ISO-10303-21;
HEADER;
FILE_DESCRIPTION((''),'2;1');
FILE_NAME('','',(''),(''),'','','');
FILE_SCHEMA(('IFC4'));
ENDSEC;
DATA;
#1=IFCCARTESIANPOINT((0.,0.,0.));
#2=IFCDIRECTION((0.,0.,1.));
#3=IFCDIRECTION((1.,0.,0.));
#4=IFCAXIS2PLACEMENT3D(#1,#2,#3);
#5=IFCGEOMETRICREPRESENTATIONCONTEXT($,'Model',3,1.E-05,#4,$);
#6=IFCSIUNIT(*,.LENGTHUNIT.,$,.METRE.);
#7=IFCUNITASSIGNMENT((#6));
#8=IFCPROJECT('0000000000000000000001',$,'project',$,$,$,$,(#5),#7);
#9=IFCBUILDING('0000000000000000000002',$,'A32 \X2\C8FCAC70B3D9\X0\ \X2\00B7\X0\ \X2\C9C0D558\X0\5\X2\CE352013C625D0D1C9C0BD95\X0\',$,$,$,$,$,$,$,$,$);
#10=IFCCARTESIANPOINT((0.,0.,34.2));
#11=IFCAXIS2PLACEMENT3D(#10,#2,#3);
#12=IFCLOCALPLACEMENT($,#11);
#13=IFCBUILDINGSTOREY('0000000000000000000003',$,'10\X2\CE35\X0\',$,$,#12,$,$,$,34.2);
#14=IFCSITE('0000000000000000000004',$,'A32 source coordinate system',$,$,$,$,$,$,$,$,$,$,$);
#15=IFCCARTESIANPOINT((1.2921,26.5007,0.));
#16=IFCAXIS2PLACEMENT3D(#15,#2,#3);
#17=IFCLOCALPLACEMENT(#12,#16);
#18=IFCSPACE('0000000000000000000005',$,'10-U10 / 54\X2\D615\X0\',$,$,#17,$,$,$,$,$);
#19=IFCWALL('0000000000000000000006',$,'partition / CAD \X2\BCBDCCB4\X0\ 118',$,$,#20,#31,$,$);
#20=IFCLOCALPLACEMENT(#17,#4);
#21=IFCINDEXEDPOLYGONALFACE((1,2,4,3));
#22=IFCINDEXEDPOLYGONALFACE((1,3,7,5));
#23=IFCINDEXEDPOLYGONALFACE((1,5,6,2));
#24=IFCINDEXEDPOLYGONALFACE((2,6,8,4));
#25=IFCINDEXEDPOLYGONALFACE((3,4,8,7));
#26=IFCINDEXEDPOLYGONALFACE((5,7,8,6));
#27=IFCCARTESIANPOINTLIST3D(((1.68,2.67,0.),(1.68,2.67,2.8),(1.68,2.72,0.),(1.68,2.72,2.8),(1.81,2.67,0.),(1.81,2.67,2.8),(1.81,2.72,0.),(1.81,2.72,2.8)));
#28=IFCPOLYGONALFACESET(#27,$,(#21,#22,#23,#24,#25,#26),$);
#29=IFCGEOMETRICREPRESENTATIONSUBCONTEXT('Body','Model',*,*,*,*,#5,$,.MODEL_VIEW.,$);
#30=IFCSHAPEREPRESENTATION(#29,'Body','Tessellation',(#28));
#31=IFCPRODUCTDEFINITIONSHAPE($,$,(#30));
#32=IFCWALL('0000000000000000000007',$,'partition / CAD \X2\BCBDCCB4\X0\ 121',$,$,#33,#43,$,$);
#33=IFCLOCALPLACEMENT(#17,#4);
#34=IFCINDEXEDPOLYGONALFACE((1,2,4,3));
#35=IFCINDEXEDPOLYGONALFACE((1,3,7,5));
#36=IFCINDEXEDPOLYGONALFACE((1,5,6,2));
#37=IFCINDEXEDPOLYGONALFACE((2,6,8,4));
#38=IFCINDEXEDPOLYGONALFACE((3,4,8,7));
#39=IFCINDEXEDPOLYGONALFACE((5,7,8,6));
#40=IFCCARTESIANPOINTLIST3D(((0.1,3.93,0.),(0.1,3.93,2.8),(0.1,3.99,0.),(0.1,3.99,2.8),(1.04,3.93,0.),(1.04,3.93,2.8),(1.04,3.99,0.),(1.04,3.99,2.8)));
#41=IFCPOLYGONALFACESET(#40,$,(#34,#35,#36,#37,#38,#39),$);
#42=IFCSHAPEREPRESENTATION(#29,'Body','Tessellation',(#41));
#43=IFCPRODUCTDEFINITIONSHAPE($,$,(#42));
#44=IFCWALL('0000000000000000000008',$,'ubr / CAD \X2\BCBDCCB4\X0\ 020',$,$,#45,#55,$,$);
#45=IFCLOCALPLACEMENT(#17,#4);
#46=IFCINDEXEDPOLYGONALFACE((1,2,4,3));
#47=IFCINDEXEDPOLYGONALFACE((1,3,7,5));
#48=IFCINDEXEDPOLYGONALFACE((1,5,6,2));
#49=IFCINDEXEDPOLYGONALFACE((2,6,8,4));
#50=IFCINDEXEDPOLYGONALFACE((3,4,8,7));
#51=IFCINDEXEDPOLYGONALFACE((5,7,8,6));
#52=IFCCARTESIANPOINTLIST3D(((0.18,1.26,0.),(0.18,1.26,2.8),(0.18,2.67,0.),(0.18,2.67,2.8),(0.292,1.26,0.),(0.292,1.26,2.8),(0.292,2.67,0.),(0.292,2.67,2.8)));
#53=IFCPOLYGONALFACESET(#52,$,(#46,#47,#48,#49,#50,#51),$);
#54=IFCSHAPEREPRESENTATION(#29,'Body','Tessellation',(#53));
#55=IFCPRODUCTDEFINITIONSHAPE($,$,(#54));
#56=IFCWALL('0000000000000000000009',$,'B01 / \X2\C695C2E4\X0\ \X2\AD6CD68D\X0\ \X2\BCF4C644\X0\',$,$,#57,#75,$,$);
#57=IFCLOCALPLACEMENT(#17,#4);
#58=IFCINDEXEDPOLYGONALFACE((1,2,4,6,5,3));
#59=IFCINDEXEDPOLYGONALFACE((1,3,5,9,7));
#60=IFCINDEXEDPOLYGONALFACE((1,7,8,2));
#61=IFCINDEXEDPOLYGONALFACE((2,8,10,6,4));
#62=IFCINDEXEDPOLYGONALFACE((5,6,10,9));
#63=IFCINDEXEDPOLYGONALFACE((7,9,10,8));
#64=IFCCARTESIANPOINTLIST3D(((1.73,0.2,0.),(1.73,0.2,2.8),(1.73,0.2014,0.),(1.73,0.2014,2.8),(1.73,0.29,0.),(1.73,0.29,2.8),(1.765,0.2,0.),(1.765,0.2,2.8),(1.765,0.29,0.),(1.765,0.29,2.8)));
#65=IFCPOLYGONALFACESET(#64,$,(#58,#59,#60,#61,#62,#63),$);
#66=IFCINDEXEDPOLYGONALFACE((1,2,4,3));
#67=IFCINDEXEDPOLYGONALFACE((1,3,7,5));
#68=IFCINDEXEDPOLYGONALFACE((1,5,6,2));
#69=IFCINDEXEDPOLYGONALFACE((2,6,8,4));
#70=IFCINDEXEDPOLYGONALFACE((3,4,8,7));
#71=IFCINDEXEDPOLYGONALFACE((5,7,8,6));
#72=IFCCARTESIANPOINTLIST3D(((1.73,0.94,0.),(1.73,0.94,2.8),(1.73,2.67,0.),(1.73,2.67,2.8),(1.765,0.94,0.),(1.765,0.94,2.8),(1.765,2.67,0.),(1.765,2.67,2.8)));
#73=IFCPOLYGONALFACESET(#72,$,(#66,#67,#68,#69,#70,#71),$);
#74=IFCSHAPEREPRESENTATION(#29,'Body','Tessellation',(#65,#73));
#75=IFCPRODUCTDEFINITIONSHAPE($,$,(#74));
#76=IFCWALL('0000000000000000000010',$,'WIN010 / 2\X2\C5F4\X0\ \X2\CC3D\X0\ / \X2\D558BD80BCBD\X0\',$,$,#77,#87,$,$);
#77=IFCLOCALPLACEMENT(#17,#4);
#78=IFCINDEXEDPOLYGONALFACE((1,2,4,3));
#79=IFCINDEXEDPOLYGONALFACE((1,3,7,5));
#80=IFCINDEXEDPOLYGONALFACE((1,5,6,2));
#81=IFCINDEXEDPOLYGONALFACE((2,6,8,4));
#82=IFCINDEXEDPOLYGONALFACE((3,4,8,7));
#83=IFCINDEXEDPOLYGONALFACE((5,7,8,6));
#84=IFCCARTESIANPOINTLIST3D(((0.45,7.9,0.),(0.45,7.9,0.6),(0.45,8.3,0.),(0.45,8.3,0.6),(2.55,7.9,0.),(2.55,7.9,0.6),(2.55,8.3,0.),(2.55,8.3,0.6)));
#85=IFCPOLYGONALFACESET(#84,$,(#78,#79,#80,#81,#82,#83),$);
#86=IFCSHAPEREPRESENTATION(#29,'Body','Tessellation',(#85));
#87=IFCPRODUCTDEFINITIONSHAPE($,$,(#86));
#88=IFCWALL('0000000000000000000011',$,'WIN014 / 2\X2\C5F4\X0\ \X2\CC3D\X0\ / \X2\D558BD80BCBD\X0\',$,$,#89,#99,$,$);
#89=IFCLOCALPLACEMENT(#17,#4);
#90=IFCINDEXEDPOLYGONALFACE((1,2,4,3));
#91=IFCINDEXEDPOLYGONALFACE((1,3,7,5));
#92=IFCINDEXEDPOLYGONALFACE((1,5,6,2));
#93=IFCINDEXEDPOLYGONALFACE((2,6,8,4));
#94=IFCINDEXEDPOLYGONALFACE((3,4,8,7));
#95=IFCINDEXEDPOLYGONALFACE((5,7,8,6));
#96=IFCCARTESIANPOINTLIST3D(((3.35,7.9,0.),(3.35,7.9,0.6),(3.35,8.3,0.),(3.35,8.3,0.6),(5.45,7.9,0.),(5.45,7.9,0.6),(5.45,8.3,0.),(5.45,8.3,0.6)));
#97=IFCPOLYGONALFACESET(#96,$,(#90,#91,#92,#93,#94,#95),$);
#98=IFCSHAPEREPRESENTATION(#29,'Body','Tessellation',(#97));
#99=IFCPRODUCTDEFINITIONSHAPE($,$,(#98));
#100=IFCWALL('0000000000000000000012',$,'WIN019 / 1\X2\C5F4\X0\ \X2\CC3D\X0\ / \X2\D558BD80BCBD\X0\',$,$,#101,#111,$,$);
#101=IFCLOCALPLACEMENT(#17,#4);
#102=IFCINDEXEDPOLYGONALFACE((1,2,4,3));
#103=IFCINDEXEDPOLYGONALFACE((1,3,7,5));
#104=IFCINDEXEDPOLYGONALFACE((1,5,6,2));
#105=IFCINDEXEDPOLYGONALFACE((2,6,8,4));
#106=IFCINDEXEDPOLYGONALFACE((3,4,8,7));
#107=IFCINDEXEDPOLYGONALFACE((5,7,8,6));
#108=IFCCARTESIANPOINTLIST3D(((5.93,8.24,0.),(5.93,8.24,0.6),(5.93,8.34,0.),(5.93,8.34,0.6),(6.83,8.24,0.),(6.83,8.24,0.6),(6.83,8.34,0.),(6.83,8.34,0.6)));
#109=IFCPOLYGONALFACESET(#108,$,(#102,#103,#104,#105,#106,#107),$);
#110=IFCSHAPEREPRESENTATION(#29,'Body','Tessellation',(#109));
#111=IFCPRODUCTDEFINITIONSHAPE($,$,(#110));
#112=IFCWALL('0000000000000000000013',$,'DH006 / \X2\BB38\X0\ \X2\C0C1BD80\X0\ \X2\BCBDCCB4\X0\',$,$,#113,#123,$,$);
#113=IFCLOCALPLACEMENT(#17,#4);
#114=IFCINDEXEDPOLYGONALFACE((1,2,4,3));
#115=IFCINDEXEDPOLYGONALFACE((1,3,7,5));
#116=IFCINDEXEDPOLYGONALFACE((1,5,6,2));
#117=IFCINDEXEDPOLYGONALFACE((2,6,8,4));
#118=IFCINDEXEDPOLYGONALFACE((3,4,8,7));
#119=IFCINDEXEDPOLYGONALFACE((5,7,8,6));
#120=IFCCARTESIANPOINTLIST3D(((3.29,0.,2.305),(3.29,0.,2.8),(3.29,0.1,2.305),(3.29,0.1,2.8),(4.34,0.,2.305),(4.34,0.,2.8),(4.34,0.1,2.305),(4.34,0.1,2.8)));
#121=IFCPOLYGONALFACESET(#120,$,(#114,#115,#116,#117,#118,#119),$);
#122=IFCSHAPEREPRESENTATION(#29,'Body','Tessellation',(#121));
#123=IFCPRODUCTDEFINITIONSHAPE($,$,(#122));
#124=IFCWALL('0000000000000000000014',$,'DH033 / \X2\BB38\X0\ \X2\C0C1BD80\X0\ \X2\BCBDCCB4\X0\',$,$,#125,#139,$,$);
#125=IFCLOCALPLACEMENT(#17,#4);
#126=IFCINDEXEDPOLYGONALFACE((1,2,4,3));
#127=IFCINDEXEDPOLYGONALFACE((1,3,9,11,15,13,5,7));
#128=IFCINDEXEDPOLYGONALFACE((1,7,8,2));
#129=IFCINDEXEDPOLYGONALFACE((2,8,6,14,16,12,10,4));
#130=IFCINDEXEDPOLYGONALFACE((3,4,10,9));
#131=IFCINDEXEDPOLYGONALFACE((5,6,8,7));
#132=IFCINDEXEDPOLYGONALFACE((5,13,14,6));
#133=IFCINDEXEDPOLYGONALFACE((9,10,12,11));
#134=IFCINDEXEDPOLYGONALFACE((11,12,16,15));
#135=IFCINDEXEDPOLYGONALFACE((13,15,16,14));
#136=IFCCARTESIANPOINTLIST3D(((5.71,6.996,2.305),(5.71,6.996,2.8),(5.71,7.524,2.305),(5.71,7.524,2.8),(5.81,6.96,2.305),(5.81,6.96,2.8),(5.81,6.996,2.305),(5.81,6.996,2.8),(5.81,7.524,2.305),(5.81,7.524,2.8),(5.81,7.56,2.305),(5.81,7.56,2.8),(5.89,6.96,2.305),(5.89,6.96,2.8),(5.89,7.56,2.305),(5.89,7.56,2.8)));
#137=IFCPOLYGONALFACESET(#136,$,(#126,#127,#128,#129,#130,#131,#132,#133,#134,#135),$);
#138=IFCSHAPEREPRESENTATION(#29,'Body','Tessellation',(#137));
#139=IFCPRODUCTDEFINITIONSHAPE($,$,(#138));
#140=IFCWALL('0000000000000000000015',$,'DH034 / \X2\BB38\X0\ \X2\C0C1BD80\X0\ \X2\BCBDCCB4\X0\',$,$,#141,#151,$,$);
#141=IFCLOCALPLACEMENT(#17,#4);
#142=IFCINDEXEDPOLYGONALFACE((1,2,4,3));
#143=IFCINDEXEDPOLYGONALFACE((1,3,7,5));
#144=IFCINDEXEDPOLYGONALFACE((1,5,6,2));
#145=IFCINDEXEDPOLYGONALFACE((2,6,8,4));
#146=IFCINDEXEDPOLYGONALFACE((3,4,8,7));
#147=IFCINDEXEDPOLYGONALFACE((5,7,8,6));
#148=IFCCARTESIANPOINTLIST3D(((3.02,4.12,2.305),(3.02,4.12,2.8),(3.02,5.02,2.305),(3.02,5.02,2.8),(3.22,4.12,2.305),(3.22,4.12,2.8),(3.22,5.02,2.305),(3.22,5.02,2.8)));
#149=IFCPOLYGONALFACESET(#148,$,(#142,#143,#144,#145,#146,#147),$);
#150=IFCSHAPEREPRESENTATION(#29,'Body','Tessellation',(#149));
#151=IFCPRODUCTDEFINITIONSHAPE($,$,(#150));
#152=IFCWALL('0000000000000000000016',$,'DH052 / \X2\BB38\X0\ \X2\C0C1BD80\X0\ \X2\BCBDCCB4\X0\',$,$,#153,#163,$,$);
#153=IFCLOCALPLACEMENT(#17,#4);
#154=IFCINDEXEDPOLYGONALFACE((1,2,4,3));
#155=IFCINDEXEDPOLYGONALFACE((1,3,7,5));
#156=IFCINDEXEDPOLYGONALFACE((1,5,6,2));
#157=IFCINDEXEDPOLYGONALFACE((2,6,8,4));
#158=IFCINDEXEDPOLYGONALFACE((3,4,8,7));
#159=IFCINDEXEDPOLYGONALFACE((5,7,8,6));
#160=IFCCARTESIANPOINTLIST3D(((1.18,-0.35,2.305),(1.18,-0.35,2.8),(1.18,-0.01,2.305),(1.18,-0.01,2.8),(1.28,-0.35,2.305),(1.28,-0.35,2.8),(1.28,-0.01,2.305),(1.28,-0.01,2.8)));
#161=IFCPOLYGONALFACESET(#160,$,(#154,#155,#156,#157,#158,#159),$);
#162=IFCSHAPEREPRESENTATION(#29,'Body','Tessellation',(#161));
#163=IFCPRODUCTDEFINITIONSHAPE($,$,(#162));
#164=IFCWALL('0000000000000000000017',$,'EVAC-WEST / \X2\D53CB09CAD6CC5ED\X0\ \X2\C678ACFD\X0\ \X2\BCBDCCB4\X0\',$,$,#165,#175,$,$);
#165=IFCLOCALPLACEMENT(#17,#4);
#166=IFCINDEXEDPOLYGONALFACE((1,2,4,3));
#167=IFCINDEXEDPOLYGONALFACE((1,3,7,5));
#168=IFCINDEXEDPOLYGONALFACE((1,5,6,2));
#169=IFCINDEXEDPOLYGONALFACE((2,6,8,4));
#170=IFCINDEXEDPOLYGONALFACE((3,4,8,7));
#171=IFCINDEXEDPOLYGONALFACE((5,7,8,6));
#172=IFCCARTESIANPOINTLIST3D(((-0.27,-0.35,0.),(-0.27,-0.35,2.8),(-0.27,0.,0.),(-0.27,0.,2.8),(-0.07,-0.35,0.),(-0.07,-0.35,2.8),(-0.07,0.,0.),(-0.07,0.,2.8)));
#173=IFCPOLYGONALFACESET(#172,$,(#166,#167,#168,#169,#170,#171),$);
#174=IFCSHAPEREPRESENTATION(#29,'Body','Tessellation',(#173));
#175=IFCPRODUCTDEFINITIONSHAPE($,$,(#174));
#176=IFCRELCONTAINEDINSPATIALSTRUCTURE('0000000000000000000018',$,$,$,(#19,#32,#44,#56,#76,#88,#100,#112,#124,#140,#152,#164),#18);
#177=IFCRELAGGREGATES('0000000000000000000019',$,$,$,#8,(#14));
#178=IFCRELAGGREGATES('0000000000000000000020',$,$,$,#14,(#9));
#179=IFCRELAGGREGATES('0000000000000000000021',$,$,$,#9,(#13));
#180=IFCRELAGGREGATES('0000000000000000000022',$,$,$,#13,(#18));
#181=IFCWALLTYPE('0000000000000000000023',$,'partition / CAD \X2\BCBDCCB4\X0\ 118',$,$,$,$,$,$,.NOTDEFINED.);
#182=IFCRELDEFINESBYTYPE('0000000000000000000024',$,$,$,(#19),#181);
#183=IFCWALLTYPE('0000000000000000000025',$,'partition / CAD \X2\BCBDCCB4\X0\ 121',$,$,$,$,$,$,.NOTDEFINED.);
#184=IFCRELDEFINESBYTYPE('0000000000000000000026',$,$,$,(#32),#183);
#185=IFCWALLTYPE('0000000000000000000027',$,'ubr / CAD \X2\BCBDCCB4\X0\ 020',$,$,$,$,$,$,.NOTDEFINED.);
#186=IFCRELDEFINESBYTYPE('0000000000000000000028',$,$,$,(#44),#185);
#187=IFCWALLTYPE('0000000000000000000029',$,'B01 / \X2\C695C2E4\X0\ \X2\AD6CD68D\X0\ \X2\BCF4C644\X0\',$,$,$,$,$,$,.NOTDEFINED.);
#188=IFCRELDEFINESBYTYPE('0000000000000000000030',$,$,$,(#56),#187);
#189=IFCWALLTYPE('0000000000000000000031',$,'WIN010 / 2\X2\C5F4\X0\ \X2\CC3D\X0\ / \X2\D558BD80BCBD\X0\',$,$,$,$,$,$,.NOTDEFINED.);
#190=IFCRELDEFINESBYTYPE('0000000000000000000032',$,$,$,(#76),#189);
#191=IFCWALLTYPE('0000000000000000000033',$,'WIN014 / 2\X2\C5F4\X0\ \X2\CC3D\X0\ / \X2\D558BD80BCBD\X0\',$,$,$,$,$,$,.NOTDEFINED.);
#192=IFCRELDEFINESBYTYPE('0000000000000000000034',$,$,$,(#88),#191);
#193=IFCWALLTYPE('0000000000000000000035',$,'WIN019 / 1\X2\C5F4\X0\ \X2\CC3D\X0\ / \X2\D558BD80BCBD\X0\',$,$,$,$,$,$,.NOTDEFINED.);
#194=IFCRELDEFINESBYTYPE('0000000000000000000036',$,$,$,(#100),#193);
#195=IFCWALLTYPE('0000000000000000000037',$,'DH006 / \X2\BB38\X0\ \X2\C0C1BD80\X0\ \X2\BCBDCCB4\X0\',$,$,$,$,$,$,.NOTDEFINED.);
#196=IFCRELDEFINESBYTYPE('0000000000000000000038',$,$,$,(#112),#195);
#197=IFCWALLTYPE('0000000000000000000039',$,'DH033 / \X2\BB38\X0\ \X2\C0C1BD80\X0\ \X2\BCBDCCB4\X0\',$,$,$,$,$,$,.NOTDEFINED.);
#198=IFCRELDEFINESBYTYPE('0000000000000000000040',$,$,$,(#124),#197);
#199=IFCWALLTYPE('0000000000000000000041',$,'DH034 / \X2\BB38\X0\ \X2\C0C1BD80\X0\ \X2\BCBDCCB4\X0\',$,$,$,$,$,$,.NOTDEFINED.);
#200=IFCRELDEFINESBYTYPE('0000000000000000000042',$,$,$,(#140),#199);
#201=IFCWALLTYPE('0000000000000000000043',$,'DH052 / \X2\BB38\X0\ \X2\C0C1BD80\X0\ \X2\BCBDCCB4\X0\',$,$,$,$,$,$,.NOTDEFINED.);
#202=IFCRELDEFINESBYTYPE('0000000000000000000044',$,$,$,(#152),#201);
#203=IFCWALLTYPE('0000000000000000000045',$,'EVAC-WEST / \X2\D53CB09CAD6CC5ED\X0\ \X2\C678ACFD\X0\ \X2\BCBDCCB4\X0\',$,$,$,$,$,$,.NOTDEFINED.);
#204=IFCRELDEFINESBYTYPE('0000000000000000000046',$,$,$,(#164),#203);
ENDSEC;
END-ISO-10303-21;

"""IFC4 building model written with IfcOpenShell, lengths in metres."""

from ifc_helpers import new_model, si_unit, frame, origin, origin_with_axes, place, context, subcontext, project, spatial, polyline, outline, extrude, source, transform, mapped, type_object, type_shapes, element, save


model = new_model("IFC4")

# Units and contexts
model_context = context("Model", 3, precision=1e-05, world=origin_with_axes())
body_context = subcontext(model_context, "Body", "Model", "MODEL_VIEW")
ifc_project = project(units=[si_unit("LENGTHUNIT", "METRE")], contexts=[model_context])

# Site, building, storey, space
site = spatial("IfcSite", under=ifc_project, Name="A32 source coordinate system")
building = spatial("IfcBuilding", under=site, Name="A32 주거동 · 지하5층–옥탑지붕")
storey_placement = place(None, frame((0.0, 0.0, 34.2), z_axis=(0.0, 0.0, 1.0), x_axis=(1.0, 0.0, 0.0)))
storey = spatial("IfcBuildingStorey", under=building, at=storey_placement, Name="10층", Elevation=34.2)
space_placement = place(storey_placement, frame((1.2921, 26.5007, 0.0), z_axis=(0.0, 0.0, 1.0), x_axis=(1.0, 0.0, 0.0)))
space = spatial("IfcSpace", under=storey, at=space_placement, Name="10-U10 / 54형")

# Walls
wall_type_1 = type_object("IfcWallType", Name="partition / CAD 벽체 118", PredefinedType="NOTDEFINED")
shared_shape_1 = source(origin(), body_context, "Body", "SweptSolid", [
    extrude(outline(polyline([(1.81, 2.67), (1.68, 2.67), (1.68, 2.72), (1.81, 2.72), (1.81, 2.67)])), origin(), (0.0, 0.0, 1.0), 2.8),
])
type_shapes(wall_type_1, [shared_shape_1])
wall_1_placement = place(space_placement, origin_with_axes())
element("IfcWall", 1, at=wall_1_placement, inside=space, type_object=wall_type_1, Name="partition / CAD 벽체 118", context=body_context, shape_type="MappedRepresentation", body=[
    mapped(shared_shape_1, transform((0.0, 0.0, 0.0), scale=1.0)),
])
wall_type_2 = type_object("IfcWallType", Name="partition / CAD 벽체 121", PredefinedType="NOTDEFINED")
shared_shape_2 = source(origin(), body_context, "Body", "SweptSolid", [
    extrude(outline(polyline([(0.1, 3.99), (1.04, 3.99), (1.04, 3.93), (0.1, 3.93), (0.1, 3.99)])), origin(), (0.0, 0.0, 1.0), 2.8),
])
type_shapes(wall_type_2, [shared_shape_2])
wall_2_placement = place(space_placement, origin_with_axes())
element("IfcWall", 2, at=wall_2_placement, inside=space, type_object=wall_type_2, Name="partition / CAD 벽체 121", context=body_context, shape_type="MappedRepresentation", body=[
    mapped(shared_shape_2, transform((0.0, 0.0, 0.0), scale=1.0)),
])
wall_type_3 = type_object("IfcWallType", Name="ubr / CAD 벽체 020", PredefinedType="NOTDEFINED")
shared_shape_3 = source(origin(), body_context, "Body", "SweptSolid", [
    extrude(outline(polyline([(0.18, 1.26), (0.18, 2.67), (0.292, 2.67), (0.292, 1.26), (0.18, 1.26)])), origin(), (0.0, 0.0, 1.0), 2.8),
])
type_shapes(wall_type_3, [shared_shape_3])
wall_3_placement = place(space_placement, origin_with_axes())
element("IfcWall", 3, at=wall_3_placement, inside=space, type_object=wall_type_3, Name="ubr / CAD 벽체 020", context=body_context, shape_type="MappedRepresentation", body=[
    mapped(shared_shape_3, transform((0.0, 0.0, 0.0), scale=1.0)),
])
wall_type_4 = type_object("IfcWallType", Name="B01 / 욕실 구획 보완", PredefinedType="NOTDEFINED")
shared_shape_4 = source(origin(), body_context, "Body", "SweptSolid", [
    extrude(outline(polyline([(1.765, 0.2), (1.73, 0.2), (1.73, 0.2014), (1.73, 0.29), (1.765, 0.29), (1.765, 0.2)])), origin(), (0.0, 0.0, 1.0), 2.8),
    extrude(outline(polyline([(1.765, 2.67), (1.765, 0.94), (1.73, 0.94), (1.73, 2.67), (1.765, 2.67)])), origin(), (0.0, 0.0, 1.0), 2.8),
])
type_shapes(wall_type_4, [shared_shape_4])
wall_4_placement = place(space_placement, origin_with_axes())
element("IfcWall", 4, at=wall_4_placement, inside=space, type_object=wall_type_4, Name="B01 / 욕실 구획 보완", context=body_context, shape_type="MappedRepresentation", body=[
    mapped(shared_shape_4, transform((0.0, 0.0, 0.0), scale=1.0)),
])
wall_type_5 = type_object("IfcWallType", Name="WIN010 / 2열 창 / 하부벽", PredefinedType="NOTDEFINED")
shared_shape_5 = source(origin(), body_context, "Body", "SweptSolid", [
    extrude(outline(polyline([(2.55, 8.3), (2.55, 7.9), (0.45, 7.9), (0.45, 8.3), (2.55, 8.3)])), origin(), (0.0, 0.0, 1.0), 0.6),
])
type_shapes(wall_type_5, [shared_shape_5])
wall_5_placement = place(space_placement, origin_with_axes())
element("IfcWall", 5, at=wall_5_placement, inside=space, type_object=wall_type_5, Name="WIN010 / 2열 창 / 하부벽", context=body_context, shape_type="MappedRepresentation", body=[
    mapped(shared_shape_5, transform((0.0, 0.0, 0.0), scale=1.0)),
])
wall_type_6 = type_object("IfcWallType", Name="WIN014 / 2열 창 / 하부벽", PredefinedType="NOTDEFINED")
shared_shape_6 = source(origin(), body_context, "Body", "SweptSolid", [
    extrude(outline(polyline([(5.45, 8.3), (5.45, 7.9), (3.35, 7.9), (3.35, 8.3), (5.45, 8.3)])), origin(), (0.0, 0.0, 1.0), 0.6),
])
type_shapes(wall_type_6, [shared_shape_6])
wall_6_placement = place(space_placement, origin_with_axes())
element("IfcWall", 6, at=wall_6_placement, inside=space, type_object=wall_type_6, Name="WIN014 / 2열 창 / 하부벽", context=body_context, shape_type="MappedRepresentation", body=[
    mapped(shared_shape_6, transform((0.0, 0.0, 0.0), scale=1.0)),
])
wall_type_7 = type_object("IfcWallType", Name="WIN019 / 1열 창 / 하부벽", PredefinedType="NOTDEFINED")
shared_shape_7 = source(origin(), body_context, "Body", "SweptSolid", [
    extrude(outline(polyline([(6.83, 8.34), (6.83, 8.24), (5.93, 8.24), (5.93, 8.34), (6.83, 8.34)])), origin(), (0.0, 0.0, 1.0), 0.6),
])
type_shapes(wall_type_7, [shared_shape_7])
wall_7_placement = place(space_placement, origin_with_axes())
element("IfcWall", 7, at=wall_7_placement, inside=space, type_object=wall_type_7, Name="WIN019 / 1열 창 / 하부벽", context=body_context, shape_type="MappedRepresentation", body=[
    mapped(shared_shape_7, transform((0.0, 0.0, 0.0), scale=1.0)),
])
wall_type_8 = type_object("IfcWallType", Name="DH006 / 문 상부 벽체", PredefinedType="NOTDEFINED")
shared_shape_8 = source(origin(), body_context, "Body", "SweptSolid", [
    extrude(outline(polyline([(4.34, 0.0), (3.29, 0.0), (3.29, 0.1), (4.34, 0.1), (4.34, 0.0)])), frame((0.0, 0.0, 2.305)), (0.0, 0.0, 1.0), 0.495),
])
type_shapes(wall_type_8, [shared_shape_8])
wall_8_placement = place(space_placement, origin_with_axes())
element("IfcWall", 8, at=wall_8_placement, inside=space, type_object=wall_type_8, Name="DH006 / 문 상부 벽체", context=body_context, shape_type="MappedRepresentation", body=[
    mapped(shared_shape_8, transform((0.0, 0.0, 0.0), scale=1.0)),
])
wall_type_9 = type_object("IfcWallType", Name="DH033 / 문 상부 벽체", PredefinedType="NOTDEFINED")
shared_shape_9 = source(origin(), body_context, "Body", "SweptSolid", [
    extrude(outline(polyline([(5.81, 6.996), (5.71, 6.996), (5.71, 7.524), (5.81, 7.524), (5.81, 7.56), (5.89, 7.56), (5.89, 6.96), (5.81, 6.96), (5.81, 6.996)])), frame((0.0, 0.0, 2.305)), (0.0, 0.0, 1.0), 0.495),
])
type_shapes(wall_type_9, [shared_shape_9])
wall_9_placement = place(space_placement, origin_with_axes())
element("IfcWall", 9, at=wall_9_placement, inside=space, type_object=wall_type_9, Name="DH033 / 문 상부 벽체", context=body_context, shape_type="MappedRepresentation", body=[
    mapped(shared_shape_9, transform((0.0, 0.0, 0.0), scale=1.0)),
])
wall_type_10 = type_object("IfcWallType", Name="DH034 / 문 상부 벽체", PredefinedType="NOTDEFINED")
shared_shape_10 = source(origin(), body_context, "Body", "SweptSolid", [
    extrude(outline(polyline([(3.22, 4.12), (3.02, 4.12), (3.02, 5.02), (3.22, 5.02), (3.22, 4.12)])), frame((0.0, 0.0, 2.305)), (0.0, 0.0, 1.0), 0.495),
])
type_shapes(wall_type_10, [shared_shape_10])
wall_10_placement = place(space_placement, origin_with_axes())
element("IfcWall", 10, at=wall_10_placement, inside=space, type_object=wall_type_10, Name="DH034 / 문 상부 벽체", context=body_context, shape_type="MappedRepresentation", body=[
    mapped(shared_shape_10, transform((0.0, 0.0, 0.0), scale=1.0)),
])
wall_type_11 = type_object("IfcWallType", Name="DH052 / 문 상부 벽체", PredefinedType="NOTDEFINED")
shared_shape_11 = source(origin(), body_context, "Body", "SweptSolid", [
    extrude(outline(polyline([(1.28, -0.35), (1.18, -0.35), (1.18, -0.01), (1.28, -0.01), (1.28, -0.35)])), frame((0.0, 0.0, 2.305)), (0.0, 0.0, 1.0), 0.495),
])
type_shapes(wall_type_11, [shared_shape_11])
wall_11_placement = place(space_placement, origin_with_axes())
element("IfcWall", 11, at=wall_11_placement, inside=space, type_object=wall_type_11, Name="DH052 / 문 상부 벽체", context=body_context, shape_type="MappedRepresentation", body=[
    mapped(shared_shape_11, transform((0.0, 0.0, 0.0), scale=1.0)),
])
wall_type_12 = type_object("IfcWallType", Name="EVAC-WEST / 피난구역 외곽 벽체", PredefinedType="NOTDEFINED")
shared_shape_12 = source(origin(), body_context, "Body", "SweptSolid", [
    extrude(outline(polyline([(-0.07, 0.0), (-0.07, -0.35), (-0.27, -0.35), (-0.27, 0.0), (-0.07, 0.0)])), origin(), (0.0, 0.0, 1.0), 2.8),
])
type_shapes(wall_type_12, [shared_shape_12])
wall_12_placement = place(space_placement, origin_with_axes())
element("IfcWall", 12, at=wall_12_placement, inside=space, type_object=wall_type_12, Name="EVAC-WEST / 피난구역 외곽 벽체", context=body_context, shape_type="MappedRepresentation", body=[
    mapped(shared_shape_12, transform((0.0, 0.0, 0.0), scale=1.0)),
])

save(model, "model.ifc")
